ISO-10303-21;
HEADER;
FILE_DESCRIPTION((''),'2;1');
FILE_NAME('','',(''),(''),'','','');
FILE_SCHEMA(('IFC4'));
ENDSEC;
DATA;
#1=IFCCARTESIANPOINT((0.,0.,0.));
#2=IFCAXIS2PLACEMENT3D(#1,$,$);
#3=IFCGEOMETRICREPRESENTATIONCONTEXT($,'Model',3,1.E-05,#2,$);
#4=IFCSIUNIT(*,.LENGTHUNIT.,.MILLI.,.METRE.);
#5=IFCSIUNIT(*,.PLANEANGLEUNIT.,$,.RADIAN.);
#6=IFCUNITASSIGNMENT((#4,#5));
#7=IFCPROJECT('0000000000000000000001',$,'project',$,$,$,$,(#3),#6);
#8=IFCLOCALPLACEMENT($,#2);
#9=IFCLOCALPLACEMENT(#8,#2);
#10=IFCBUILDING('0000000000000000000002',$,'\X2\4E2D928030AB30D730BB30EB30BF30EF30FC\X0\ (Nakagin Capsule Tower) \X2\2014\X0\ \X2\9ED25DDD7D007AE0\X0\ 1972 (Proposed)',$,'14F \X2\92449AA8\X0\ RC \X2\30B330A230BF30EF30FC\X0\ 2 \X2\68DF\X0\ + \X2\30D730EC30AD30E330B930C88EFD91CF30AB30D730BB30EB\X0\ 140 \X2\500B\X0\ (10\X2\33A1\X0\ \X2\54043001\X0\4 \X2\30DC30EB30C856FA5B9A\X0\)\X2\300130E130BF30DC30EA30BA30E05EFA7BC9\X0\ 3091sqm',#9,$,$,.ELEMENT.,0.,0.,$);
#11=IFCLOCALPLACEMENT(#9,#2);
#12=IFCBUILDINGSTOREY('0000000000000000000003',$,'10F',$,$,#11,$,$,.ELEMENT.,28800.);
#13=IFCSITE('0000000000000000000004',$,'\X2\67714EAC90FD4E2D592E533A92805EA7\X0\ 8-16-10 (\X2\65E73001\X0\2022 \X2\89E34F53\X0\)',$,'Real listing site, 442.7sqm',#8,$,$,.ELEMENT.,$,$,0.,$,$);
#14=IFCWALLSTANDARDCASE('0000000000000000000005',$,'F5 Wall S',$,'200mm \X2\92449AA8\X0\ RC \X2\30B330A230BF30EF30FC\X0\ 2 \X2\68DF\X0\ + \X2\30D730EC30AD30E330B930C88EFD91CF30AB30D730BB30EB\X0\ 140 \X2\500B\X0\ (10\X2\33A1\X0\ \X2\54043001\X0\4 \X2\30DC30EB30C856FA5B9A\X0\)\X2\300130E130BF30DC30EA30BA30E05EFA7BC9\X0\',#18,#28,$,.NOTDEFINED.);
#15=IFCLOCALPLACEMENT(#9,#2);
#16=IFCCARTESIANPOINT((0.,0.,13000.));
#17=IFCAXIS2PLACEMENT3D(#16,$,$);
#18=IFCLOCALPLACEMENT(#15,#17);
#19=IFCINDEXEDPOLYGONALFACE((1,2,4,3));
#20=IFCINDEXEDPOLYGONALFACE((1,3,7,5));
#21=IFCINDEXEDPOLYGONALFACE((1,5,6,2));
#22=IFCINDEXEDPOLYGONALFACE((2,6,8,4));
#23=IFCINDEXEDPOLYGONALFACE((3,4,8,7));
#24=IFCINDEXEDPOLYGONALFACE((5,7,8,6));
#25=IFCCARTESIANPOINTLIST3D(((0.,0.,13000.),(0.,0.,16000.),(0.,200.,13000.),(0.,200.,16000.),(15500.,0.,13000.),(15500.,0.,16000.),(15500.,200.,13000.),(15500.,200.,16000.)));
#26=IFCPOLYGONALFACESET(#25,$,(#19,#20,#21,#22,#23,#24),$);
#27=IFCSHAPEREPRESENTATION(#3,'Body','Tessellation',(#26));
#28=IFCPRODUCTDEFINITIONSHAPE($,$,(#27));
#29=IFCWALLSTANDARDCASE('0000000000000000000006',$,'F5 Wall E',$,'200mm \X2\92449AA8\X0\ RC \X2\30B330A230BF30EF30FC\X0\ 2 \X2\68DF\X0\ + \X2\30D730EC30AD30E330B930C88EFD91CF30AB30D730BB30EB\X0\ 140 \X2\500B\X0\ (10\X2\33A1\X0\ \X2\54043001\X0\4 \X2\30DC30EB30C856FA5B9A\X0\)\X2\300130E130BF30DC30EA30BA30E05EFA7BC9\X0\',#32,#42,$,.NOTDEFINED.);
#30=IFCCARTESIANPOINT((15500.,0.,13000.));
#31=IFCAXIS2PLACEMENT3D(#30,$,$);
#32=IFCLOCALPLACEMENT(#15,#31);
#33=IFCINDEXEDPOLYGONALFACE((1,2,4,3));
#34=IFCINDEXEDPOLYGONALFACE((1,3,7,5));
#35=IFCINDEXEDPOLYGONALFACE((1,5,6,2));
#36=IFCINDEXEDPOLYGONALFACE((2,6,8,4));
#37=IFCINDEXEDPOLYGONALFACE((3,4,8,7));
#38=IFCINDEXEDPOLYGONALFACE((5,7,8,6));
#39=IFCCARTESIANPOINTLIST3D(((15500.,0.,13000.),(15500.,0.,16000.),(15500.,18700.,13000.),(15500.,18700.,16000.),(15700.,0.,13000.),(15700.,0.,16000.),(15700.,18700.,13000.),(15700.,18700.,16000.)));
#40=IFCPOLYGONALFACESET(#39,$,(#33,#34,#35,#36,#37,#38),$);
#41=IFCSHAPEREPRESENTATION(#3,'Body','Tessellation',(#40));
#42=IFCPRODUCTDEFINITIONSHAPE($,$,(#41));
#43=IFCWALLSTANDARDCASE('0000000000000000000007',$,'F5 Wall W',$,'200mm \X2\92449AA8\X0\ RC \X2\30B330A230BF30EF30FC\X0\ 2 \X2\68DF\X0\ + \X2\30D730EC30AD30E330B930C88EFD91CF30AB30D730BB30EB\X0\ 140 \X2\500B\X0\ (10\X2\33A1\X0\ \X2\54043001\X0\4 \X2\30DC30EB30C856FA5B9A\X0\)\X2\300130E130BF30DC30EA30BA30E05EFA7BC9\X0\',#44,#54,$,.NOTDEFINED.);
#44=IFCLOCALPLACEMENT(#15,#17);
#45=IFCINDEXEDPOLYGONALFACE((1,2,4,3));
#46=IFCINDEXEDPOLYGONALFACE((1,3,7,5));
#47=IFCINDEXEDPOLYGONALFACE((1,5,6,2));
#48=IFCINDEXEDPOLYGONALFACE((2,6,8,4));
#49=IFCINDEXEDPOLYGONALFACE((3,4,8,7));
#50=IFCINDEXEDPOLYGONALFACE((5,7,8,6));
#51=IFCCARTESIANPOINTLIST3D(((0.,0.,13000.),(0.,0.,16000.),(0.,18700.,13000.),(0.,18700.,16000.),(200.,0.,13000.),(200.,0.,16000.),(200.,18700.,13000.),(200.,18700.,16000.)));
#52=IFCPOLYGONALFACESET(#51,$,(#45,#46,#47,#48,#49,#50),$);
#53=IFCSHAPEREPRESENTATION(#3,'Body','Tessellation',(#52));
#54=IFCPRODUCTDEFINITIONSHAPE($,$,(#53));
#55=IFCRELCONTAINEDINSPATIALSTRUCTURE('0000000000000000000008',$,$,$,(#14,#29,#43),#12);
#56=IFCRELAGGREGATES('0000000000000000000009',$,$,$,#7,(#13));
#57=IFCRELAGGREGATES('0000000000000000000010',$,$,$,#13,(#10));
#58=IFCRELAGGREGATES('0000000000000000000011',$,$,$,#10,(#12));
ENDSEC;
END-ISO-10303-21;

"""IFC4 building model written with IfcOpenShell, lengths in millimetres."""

from ifc_helpers import new_model, si_unit, frame, frame_2d, origin, place, context, project, spatial, rectangle, extrude, element, save


model = new_model("IFC4")

# Units and contexts
model_context = context("Model", 3, precision=1e-05, world=origin())
ifc_project = project(units=[si_unit("LENGTHUNIT", "METRE", prefix="MILLI"), si_unit("PLANEANGLEUNIT", "RADIAN")], contexts=[model_context])

# Site, building, storey
site_placement = place(None, origin())
site = spatial("IfcSite", under=ifc_project, at=site_placement, Name="東京都中央区銀座 8-16-10 (旧、2022 解体)", ObjectType="Real listing site, 442.7sqm", CompositionType="ELEMENT", RefElevation=0.0)
building_placement = place(site_placement, origin())
building = spatial("IfcBuilding", under=site, at=building_placement, Name="中銀カプセルタワー (Nakagin Capsule Tower) — 黒川紀章 1972 (Proposed)", ObjectType="14F 鉄骨 RC コアタワー 2 棟 + プレキャスト軽量カプセル 140 個 (10㎡ 各、4 ボルト固定)、メタボリズム建築 3091sqm", CompositionType="ELEMENT", ElevationOfRefHeight=0.0, ElevationOfTerrain=0.0)
storey_placement = place(building_placement, origin())
storey = spatial("IfcBuildingStorey", under=building, at=storey_placement, Name="10F", CompositionType="ELEMENT", Elevation=28800.0)

# Walls
placement = place(building_placement, origin())
wall_1_placement = place(placement, frame((0.0, 0.0, 13000.0)))
element("IfcWallStandardCase", 1, at=wall_1_placement, inside=storey, Name="F5 Wall S", ObjectType="200mm 鉄骨 RC コアタワー 2 棟 + プレキャスト軽量カプセル 140 個 (10㎡ 各、4 ボルト固定)、メタボリズム建築", PredefinedType="NOTDEFINED", context=model_context, shape_type="SweptSolid", body=[
    extrude(rectangle(XDim=15500.0, YDim=200.0, at=frame_2d((7750.0, 100.0))), frame((0.0, 0.0, 13000.0)), (0.0, 0.0, 1.0), 3000.0),
])
wall_2_placement = place(placement, frame((15500.0, 0.0, 13000.0)))
element("IfcWallStandardCase", 2, at=wall_2_placement, inside=storey, Name="F5 Wall E", ObjectType="200mm 鉄骨 RC コアタワー 2 棟 + プレキャスト軽量カプセル 140 個 (10㎡ 各、4 ボルト固定)、メタボリズム建築", PredefinedType="NOTDEFINED", context=model_context, shape_type="SweptSolid", body=[
    extrude(rectangle(XDim=200.0, YDim=18700.0, at=frame_2d((100.0, 9350.0))), frame((15500.0, 0.0, 13000.0)), (0.0, 0.0, 1.0), 3000.0),
])
wall_3_placement = place(placement, frame((0.0, 0.0, 13000.0)))
element("IfcWallStandardCase", 3, at=wall_3_placement, inside=storey, Name="F5 Wall W", ObjectType="200mm 鉄骨 RC コアタワー 2 棟 + プレキャスト軽量カプセル 140 個 (10㎡ 各、4 ボルト固定)、メタボリズム建築", PredefinedType="NOTDEFINED", context=model_context, shape_type="SweptSolid", body=[
    extrude(rectangle(XDim=200.0, YDim=18700.0, at=frame_2d((100.0, 9350.0))), frame((0.0, 0.0, 13000.0)), (0.0, 0.0, 1.0), 3000.0),
])

save(model, "model.ifc")
